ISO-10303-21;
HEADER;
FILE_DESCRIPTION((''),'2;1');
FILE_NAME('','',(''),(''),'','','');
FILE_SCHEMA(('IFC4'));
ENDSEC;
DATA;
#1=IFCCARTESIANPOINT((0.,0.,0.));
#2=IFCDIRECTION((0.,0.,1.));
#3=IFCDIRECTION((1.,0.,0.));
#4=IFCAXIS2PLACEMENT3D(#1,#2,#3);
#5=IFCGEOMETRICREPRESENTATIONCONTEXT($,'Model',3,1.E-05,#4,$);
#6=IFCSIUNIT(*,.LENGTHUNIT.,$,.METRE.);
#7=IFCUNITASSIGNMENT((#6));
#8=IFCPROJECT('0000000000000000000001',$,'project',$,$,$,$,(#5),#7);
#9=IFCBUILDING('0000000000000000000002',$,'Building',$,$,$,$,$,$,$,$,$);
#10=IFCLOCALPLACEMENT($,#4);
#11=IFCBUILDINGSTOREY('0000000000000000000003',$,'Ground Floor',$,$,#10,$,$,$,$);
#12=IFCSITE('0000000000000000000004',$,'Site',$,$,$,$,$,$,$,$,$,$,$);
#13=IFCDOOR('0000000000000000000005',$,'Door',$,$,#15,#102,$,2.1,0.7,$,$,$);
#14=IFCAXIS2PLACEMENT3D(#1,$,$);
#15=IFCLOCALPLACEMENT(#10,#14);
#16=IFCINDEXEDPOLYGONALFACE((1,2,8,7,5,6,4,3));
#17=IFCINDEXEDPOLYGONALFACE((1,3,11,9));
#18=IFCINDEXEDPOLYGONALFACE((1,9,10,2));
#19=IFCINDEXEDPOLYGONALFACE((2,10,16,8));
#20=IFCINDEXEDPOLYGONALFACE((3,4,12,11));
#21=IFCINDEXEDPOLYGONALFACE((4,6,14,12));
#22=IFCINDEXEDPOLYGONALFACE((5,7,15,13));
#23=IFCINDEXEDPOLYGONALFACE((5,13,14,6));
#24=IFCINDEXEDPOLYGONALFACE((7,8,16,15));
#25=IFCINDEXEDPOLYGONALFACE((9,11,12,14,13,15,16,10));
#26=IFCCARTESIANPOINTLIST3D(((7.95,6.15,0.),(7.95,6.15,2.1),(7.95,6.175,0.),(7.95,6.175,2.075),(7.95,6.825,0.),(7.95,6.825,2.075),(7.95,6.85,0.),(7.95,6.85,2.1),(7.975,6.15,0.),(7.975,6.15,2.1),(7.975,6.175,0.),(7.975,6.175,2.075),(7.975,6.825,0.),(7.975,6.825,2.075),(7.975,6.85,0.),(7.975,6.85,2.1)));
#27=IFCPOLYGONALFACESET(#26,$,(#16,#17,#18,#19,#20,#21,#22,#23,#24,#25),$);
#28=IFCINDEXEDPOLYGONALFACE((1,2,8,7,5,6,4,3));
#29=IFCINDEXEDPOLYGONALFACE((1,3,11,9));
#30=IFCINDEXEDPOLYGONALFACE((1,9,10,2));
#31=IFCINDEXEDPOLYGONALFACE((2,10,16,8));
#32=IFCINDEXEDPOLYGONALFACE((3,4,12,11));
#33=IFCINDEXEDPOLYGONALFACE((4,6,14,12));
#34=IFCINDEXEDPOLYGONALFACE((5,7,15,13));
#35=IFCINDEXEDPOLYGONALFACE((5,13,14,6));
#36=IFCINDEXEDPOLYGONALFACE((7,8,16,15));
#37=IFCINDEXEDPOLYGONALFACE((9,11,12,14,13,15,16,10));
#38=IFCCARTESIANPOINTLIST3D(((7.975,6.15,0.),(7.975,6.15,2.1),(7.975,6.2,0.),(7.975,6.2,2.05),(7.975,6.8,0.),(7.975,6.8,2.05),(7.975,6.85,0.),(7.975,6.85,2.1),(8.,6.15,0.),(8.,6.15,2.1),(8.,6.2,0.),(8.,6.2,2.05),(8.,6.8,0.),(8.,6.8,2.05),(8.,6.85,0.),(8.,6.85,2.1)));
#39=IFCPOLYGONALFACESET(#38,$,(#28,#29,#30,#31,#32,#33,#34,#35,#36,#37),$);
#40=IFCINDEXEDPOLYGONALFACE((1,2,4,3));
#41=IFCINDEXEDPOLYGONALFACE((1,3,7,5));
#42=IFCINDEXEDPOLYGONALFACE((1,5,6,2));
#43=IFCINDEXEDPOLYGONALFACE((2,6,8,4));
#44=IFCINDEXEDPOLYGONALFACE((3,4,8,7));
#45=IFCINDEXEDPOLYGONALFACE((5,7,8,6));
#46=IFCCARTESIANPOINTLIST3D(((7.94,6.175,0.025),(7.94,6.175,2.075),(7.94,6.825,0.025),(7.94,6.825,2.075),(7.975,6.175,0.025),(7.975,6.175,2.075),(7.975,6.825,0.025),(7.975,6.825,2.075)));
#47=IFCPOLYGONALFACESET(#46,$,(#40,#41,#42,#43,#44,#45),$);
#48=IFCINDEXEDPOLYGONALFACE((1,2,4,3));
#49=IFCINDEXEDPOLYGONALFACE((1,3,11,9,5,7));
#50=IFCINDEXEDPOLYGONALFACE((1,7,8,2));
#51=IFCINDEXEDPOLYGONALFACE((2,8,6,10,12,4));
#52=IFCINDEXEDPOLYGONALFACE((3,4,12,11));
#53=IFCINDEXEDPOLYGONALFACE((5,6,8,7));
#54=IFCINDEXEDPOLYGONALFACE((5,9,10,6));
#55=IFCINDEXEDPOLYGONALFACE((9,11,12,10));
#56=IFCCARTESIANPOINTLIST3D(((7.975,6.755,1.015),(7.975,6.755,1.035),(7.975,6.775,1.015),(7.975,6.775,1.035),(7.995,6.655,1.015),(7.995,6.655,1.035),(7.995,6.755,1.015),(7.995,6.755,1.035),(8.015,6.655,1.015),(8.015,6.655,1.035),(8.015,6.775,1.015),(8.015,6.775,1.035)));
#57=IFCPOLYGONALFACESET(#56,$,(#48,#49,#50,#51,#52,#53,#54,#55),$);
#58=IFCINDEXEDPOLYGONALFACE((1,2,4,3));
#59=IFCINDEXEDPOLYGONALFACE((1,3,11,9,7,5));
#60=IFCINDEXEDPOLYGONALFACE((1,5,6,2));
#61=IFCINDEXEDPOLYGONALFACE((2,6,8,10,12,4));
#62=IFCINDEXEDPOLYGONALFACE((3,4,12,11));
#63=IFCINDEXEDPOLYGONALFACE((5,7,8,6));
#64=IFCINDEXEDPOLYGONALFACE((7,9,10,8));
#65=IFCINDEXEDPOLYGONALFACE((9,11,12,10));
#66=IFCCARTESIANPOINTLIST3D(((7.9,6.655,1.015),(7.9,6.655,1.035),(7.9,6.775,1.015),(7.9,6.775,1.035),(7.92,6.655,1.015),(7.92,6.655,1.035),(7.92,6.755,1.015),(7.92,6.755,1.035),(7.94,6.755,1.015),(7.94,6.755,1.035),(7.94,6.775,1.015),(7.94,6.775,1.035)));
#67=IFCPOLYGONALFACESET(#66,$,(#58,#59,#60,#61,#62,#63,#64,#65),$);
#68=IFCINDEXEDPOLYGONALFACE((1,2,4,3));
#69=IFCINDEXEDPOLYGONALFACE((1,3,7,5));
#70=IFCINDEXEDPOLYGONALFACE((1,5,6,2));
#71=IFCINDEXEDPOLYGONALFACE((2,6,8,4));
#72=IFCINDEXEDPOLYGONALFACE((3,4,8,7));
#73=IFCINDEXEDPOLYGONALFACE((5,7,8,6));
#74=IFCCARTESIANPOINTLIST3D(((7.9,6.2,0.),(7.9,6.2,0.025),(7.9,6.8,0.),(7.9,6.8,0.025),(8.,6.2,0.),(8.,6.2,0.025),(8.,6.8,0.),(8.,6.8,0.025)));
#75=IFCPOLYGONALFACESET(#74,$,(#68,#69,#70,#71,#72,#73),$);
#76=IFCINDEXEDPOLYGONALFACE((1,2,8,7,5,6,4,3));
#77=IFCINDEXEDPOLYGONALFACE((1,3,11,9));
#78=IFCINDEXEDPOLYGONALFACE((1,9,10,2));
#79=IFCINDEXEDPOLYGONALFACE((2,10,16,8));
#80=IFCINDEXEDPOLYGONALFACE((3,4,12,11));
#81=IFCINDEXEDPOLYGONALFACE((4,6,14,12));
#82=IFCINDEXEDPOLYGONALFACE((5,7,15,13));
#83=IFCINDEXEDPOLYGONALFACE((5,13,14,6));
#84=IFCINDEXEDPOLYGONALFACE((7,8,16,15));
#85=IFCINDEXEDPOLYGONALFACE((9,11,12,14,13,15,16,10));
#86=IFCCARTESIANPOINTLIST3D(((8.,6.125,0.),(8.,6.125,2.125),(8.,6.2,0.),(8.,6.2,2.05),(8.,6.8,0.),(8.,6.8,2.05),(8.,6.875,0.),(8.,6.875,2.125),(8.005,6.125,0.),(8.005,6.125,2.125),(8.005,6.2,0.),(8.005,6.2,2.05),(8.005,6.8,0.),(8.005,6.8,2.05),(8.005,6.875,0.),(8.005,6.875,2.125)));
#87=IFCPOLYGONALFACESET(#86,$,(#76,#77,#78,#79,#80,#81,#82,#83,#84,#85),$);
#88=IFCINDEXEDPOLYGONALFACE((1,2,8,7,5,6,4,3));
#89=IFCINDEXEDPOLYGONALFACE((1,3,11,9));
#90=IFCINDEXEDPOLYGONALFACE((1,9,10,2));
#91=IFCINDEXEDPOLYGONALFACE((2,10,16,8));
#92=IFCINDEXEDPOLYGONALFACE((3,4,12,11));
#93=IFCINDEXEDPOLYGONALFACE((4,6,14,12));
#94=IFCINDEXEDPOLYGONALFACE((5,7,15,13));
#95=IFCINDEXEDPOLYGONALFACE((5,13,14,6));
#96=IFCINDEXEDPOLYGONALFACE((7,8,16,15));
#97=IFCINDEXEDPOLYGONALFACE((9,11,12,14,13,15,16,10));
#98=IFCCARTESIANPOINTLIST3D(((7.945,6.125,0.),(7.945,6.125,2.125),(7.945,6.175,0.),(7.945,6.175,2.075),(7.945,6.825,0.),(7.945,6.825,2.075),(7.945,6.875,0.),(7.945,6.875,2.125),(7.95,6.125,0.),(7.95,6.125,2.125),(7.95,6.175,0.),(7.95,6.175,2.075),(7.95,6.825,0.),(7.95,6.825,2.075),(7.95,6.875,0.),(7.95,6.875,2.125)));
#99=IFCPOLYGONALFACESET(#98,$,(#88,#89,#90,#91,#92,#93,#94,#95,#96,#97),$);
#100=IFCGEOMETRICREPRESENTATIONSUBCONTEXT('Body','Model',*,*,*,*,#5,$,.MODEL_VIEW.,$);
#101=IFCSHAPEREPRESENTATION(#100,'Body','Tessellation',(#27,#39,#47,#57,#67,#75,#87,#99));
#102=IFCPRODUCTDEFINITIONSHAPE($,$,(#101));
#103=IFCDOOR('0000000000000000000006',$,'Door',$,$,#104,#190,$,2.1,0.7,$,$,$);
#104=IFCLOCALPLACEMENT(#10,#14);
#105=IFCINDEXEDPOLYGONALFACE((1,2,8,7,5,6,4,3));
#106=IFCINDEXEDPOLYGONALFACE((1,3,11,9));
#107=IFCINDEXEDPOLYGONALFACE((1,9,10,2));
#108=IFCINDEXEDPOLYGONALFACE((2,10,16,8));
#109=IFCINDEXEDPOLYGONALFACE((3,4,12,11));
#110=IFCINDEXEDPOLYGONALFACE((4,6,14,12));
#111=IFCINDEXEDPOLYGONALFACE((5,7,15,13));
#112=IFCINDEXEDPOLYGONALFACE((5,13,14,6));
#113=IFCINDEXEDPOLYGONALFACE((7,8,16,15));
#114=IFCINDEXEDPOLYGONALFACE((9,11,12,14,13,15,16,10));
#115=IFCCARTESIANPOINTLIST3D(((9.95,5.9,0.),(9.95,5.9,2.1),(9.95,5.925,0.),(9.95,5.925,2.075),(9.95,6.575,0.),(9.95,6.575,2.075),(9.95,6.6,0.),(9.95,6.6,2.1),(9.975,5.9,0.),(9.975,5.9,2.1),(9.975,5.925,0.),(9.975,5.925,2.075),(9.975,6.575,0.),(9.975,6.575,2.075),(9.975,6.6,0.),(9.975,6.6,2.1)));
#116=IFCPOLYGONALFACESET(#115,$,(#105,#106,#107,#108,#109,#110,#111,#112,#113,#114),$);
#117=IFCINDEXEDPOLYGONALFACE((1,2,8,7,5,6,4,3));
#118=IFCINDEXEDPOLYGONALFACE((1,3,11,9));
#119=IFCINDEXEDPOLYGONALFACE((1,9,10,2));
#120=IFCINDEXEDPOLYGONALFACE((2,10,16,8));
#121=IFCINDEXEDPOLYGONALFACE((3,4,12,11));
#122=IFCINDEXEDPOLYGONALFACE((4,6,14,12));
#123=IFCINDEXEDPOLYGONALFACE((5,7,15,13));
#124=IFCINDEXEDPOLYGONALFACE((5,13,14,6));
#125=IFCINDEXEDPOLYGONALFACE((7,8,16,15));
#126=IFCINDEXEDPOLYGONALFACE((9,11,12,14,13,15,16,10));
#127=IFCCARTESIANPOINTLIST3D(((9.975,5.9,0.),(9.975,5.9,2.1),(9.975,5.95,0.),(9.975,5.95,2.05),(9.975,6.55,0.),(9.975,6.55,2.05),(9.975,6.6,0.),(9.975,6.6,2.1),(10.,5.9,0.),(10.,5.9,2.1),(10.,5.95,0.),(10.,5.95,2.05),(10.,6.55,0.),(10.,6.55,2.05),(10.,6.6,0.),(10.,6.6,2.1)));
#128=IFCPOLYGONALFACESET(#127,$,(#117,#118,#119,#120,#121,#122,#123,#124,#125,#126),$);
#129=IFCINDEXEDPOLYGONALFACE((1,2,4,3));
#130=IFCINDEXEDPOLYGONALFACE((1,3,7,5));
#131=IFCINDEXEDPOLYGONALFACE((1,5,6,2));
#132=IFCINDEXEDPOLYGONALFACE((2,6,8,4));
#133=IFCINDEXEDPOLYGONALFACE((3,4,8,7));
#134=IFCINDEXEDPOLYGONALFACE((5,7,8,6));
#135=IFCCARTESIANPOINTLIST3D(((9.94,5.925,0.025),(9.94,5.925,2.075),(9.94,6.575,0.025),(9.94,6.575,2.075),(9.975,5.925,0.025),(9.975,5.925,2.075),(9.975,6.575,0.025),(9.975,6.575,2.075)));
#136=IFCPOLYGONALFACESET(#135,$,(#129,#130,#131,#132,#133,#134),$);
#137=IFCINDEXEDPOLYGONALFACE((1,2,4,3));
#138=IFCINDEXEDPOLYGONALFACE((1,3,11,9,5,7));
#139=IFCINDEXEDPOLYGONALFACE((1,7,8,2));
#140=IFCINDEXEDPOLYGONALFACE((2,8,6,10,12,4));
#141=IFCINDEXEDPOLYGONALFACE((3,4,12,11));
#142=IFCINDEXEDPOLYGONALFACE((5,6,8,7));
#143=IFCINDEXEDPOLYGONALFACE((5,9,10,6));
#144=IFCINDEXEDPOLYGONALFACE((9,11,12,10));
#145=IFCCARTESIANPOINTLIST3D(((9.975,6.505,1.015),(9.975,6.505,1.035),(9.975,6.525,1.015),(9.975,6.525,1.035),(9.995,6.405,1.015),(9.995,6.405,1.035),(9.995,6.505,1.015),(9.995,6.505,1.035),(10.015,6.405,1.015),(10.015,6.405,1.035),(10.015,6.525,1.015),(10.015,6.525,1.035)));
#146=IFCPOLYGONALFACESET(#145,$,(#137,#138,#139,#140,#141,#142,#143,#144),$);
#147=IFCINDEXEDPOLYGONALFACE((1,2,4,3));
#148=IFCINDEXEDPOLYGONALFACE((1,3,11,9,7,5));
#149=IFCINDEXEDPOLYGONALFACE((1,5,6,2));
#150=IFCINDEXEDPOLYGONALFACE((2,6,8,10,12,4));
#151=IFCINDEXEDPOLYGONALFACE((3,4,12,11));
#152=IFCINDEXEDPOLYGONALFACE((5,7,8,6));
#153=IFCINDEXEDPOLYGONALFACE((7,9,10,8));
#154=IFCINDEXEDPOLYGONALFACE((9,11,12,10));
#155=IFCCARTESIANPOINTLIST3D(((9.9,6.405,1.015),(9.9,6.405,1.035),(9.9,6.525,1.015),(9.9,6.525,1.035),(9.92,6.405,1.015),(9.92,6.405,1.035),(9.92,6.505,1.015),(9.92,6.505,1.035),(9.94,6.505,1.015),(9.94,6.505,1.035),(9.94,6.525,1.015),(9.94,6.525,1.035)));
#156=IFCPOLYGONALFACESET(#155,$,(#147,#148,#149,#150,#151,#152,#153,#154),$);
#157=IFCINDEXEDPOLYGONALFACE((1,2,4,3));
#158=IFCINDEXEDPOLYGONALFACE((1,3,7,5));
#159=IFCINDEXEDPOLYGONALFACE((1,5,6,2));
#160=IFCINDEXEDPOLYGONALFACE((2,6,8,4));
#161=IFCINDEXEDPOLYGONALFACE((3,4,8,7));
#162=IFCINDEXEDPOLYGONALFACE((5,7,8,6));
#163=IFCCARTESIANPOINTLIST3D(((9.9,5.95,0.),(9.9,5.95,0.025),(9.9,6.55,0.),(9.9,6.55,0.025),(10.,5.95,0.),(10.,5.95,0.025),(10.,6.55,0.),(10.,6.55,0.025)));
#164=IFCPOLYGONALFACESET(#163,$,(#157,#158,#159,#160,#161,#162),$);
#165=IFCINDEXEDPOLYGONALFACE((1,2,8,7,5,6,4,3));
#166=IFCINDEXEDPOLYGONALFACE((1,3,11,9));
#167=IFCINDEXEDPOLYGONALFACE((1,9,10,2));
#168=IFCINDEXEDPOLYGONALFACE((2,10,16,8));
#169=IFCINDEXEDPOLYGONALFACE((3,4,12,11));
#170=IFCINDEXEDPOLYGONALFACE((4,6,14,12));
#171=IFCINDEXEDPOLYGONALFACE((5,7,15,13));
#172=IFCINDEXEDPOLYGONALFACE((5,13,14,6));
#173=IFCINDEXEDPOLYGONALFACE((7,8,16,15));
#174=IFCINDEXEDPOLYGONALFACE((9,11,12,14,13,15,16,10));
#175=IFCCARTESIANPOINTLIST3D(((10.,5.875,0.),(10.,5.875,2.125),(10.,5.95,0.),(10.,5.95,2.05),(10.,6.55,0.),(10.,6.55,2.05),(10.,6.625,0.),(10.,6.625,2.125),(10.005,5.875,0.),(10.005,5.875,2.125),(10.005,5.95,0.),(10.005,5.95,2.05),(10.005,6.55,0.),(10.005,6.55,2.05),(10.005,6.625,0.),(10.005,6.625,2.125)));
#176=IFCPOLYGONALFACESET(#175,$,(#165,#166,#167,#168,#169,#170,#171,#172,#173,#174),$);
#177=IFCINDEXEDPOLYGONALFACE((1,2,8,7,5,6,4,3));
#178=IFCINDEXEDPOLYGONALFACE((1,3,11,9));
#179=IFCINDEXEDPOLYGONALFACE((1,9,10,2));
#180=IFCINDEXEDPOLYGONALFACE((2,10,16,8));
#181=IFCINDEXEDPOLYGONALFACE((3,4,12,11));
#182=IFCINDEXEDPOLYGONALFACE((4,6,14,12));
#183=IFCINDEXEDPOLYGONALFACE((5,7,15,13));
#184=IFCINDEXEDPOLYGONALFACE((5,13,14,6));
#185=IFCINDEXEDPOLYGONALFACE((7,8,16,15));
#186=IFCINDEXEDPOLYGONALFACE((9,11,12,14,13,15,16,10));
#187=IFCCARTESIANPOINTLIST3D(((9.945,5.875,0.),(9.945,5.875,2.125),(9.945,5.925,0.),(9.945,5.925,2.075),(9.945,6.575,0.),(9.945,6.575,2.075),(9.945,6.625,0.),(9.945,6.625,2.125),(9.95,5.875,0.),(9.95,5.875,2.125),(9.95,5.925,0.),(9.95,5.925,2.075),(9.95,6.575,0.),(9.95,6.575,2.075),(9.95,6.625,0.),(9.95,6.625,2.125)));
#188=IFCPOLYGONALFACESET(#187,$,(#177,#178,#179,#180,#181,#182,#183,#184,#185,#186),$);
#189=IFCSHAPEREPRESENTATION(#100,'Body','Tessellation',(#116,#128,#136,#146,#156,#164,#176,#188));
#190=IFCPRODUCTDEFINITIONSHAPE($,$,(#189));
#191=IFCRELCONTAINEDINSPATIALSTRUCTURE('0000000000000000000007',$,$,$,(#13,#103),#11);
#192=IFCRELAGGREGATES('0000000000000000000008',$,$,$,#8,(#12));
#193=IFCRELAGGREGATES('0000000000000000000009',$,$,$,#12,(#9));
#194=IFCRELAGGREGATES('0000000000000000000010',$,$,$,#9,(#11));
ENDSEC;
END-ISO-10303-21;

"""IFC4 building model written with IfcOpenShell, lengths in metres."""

from ifc_helpers import new_model, si_unit, frame, origin_with_axes, place, context, subcontext, project, spatial, line, indexed_curve, outline, extrude, element, save


model = new_model("IFC4")

# Units and contexts
model_context = context("Model", 3, precision=1e-05, world=origin_with_axes())
body_context = subcontext(model_context, "Body", "Model", "MODEL_VIEW")
ifc_project = project(units=[si_unit("LENGTHUNIT", "METRE")], contexts=[model_context])

# Site, building, storey
site = spatial("IfcSite", under=ifc_project, Name="Site")
building = spatial("IfcBuilding", under=site, Name="Building")
storey_placement = place(None, origin_with_axes())
storey = spatial("IfcBuildingStorey", under=building, at=storey_placement, Name="Ground Floor")

# Doors
door_1_placement = place(storey_placement, frame((8.0, 6.15, 0.0), z_axis=(0.0, 0.0, 1.0), x_axis=(0.0, 1.0, 0.0)))
element("IfcDoor", 1, at=door_1_placement, inside=storey, Name="Door", OverallHeight=2.1, OverallWidth=0.7, context=body_context, shape_type="SweptSolid", body=[
    extrude(outline(indexed_curve([(0.0, 0.0), (0.0, 2.1), (0.7, 2.1), (0.7, 0.0), (0.675, 0.0), (0.675, 2.075), (0.025, 2.075), (0.025, 0.0)], segments=[line(1, 2, 3, 4, 5, 6, 7, 8, 1)])), frame((0.0, 0.025, 0.0), z_axis=(0.0, -1.0, 0.0), x_axis=(1.0, 0.0, 0.0)), (0.0, 0.0, -1.0), 0.025),
    extrude(outline(indexed_curve([(0.0, 0.0), (0.0, 2.1), (0.7, 2.1), (0.7, 0.0), (0.65, 0.0), (0.65, 2.05), (0.05, 2.05), (0.05, 0.0)], segments=[line(1, 2, 3, 4, 5, 6, 7, 8, 1)])), frame((0.0, 0.0, 0.0), z_axis=(0.0, -1.0, 0.0), x_axis=(1.0, 0.0, 0.0)), (0.0, 0.0, -1.0), 0.025),
    extrude(outline(indexed_curve([(0.0, 0.0), (0.65, 0.0), (0.65, 0.035), (0.0, 0.035)], segments=[line(1, 2, 3, 4, 1)])), frame((0.025, 0.025, 0.025), z_axis=(0.0, 0.0, 1.0), x_axis=(1.0, 0.0, 0.0)), (0.0, 0.0, 1.0), 2.05),
    extrude(outline(indexed_curve([(0.0, 0.0), (0.0, -0.04), (-0.12, -0.04), (-0.12, -0.02), (-0.02, -0.02), (-0.02, 0.0)], segments=[line(1, 2, 3, 4, 5, 6, 1)])), frame((0.625, 0.025, 1.015), z_axis=(0.0, 0.0, 1.0), x_axis=(1.0, 0.0, 0.0)), (0.0, 0.0, 1.0), 0.02),
    extrude(outline(indexed_curve([(0.0, 0.0), (0.0, 0.04), (-0.12, 0.04), (-0.12, 0.02), (-0.02, 0.02), (-0.02, 0.0)], segments=[line(1, 2, 3, 4, 5, 6, 1)])), frame((0.625, 0.06, 1.015), z_axis=(0.0, 0.0, 1.0), x_axis=(1.0, 0.0, 0.0)), (0.0, 0.0, 1.0), 0.02),
    extrude(outline(indexed_curve([(0.0, 0.0), (0.6, 0.0), (0.6, 0.1), (0.0, 0.1)], segments=[line(1, 2, 3, 4, 1)])), frame((0.05, 0.0, 0.0), z_axis=(0.0, 0.0, 1.0), x_axis=(1.0, 0.0, 0.0)), (0.0, 0.0, 1.0), 0.025),
    extrude(outline(indexed_curve([(0.0, 0.0), (0.0, 2.125), (0.75, 2.125), (0.75, 0.0), (0.675, 0.0), (0.675, 2.05), (0.075, 2.05), (0.075, 0.0)], segments=[line(1, 2, 3, 4, 5, 6, 7, 8, 1)])), frame((-0.025, -0.005, 0.0), z_axis=(0.0, -1.0, 0.0), x_axis=(1.0, 0.0, 0.0)), (0.0, 0.0, -1.0), 0.005),
    extrude(outline(indexed_curve([(0.0, 0.0), (0.0, 2.125), (0.75, 2.125), (0.75, 0.0), (0.7, 0.0), (0.7, 2.075), (0.05, 2.075), (0.05, 0.0)], segments=[line(1, 2, 3, 4, 5, 6, 7, 8, 1)])), frame((-0.025, 0.05, 0.0), z_axis=(0.0, -1.0, 0.0), x_axis=(1.0, 0.0, 0.0)), (0.0, 0.0, -1.0), 0.005),
])
door_2_placement = place(storey_placement, frame((10.0, 5.9, 0.0), z_axis=(0.0, 0.0, 1.0), x_axis=(0.0, 1.0, 0.0)))
element("IfcDoor", 2, at=door_2_placement, inside=storey, Name="Door", OverallHeight=2.1, OverallWidth=0.7, context=body_context, shape_type="SweptSolid", body=[
    extrude(outline(indexed_curve([(0.0, 0.0), (0.0, 2.1), (0.7, 2.1), (0.7, 0.0), (0.675, 0.0), (0.675, 2.075), (0.025, 2.075), (0.025, 0.0)], segments=[line(1, 2, 3, 4, 5, 6, 7, 8, 1)])), frame((0.0, 0.025, 0.0), z_axis=(0.0, -1.0, 0.0), x_axis=(1.0, 0.0, 0.0)), (0.0, 0.0, -1.0), 0.025),
    extrude(outline(indexed_curve([(0.0, 0.0), (0.0, 2.1), (0.7, 2.1), (0.7, 0.0), (0.65, 0.0), (0.65, 2.05), (0.05, 2.05), (0.05, 0.0)], segments=[line(1, 2, 3, 4, 5, 6, 7, 8, 1)])), frame((0.0, 0.0, 0.0), z_axis=(0.0, -1.0, 0.0), x_axis=(1.0, 0.0, 0.0)), (0.0, 0.0, -1.0), 0.025),
    extrude(outline(indexed_curve([(0.0, 0.0), (0.65, 0.0), (0.65, 0.035), (0.0, 0.035)], segments=[line(1, 2, 3, 4, 1)])), frame((0.025, 0.025, 0.025), z_axis=(0.0, 0.0, 1.0), x_axis=(1.0, 0.0, 0.0)), (0.0, 0.0, 1.0), 2.05),
    extrude(outline(indexed_curve([(0.0, 0.0), (0.0, -0.04), (-0.12, -0.04), (-0.12, -0.02), (-0.02, -0.02), (-0.02, 0.0)], segments=[line(1, 2, 3, 4, 5, 6, 1)])), frame((0.625, 0.025, 1.015), z_axis=(0.0, 0.0, 1.0), x_axis=(1.0, 0.0, 0.0)), (0.0, 0.0, 1.0), 0.02),
    extrude(outline(indexed_curve([(0.0, 0.0), (0.0, 0.04), (-0.12, 0.04), (-0.12, 0.02), (-0.02, 0.02), (-0.02, 0.0)], segments=[line(1, 2, 3, 4, 5, 6, 1)])), frame((0.625, 0.06, 1.015), z_axis=(0.0, 0.0, 1.0), x_axis=(1.0, 0.0, 0.0)), (0.0, 0.0, 1.0), 0.02),
    extrude(outline(indexed_curve([(0.0, 0.0), (0.6, 0.0), (0.6, 0.1), (0.0, 0.1)], segments=[line(1, 2, 3, 4, 1)])), frame((0.05, 0.0, 0.0), z_axis=(0.0, 0.0, 1.0), x_axis=(1.0, 0.0, 0.0)), (0.0, 0.0, 1.0), 0.025),
    extrude(outline(indexed_curve([(0.0, 0.0), (0.0, 2.125), (0.75, 2.125), (0.75, 0.0), (0.675, 0.0), (0.675, 2.05), (0.075, 2.05), (0.075, 0.0)], segments=[line(1, 2, 3, 4, 5, 6, 7, 8, 1)])), frame((-0.025, -0.005, 0.0), z_axis=(0.0, -1.0, 0.0), x_axis=(1.0, 0.0, 0.0)), (0.0, 0.0, -1.0), 0.005),
    extrude(outline(indexed_curve([(0.0, 0.0), (0.0, 2.125), (0.75, 2.125), (0.75, 0.0), (0.7, 0.0), (0.7, 2.075), (0.05, 2.075), (0.05, 0.0)], segments=[line(1, 2, 3, 4, 5, 6, 7, 8, 1)])), frame((-0.025, 0.05, 0.0), z_axis=(0.0, -1.0, 0.0), x_axis=(1.0, 0.0, 0.0)), (0.0, 0.0, -1.0), 0.005),
])

save(model, "model.ifc")
